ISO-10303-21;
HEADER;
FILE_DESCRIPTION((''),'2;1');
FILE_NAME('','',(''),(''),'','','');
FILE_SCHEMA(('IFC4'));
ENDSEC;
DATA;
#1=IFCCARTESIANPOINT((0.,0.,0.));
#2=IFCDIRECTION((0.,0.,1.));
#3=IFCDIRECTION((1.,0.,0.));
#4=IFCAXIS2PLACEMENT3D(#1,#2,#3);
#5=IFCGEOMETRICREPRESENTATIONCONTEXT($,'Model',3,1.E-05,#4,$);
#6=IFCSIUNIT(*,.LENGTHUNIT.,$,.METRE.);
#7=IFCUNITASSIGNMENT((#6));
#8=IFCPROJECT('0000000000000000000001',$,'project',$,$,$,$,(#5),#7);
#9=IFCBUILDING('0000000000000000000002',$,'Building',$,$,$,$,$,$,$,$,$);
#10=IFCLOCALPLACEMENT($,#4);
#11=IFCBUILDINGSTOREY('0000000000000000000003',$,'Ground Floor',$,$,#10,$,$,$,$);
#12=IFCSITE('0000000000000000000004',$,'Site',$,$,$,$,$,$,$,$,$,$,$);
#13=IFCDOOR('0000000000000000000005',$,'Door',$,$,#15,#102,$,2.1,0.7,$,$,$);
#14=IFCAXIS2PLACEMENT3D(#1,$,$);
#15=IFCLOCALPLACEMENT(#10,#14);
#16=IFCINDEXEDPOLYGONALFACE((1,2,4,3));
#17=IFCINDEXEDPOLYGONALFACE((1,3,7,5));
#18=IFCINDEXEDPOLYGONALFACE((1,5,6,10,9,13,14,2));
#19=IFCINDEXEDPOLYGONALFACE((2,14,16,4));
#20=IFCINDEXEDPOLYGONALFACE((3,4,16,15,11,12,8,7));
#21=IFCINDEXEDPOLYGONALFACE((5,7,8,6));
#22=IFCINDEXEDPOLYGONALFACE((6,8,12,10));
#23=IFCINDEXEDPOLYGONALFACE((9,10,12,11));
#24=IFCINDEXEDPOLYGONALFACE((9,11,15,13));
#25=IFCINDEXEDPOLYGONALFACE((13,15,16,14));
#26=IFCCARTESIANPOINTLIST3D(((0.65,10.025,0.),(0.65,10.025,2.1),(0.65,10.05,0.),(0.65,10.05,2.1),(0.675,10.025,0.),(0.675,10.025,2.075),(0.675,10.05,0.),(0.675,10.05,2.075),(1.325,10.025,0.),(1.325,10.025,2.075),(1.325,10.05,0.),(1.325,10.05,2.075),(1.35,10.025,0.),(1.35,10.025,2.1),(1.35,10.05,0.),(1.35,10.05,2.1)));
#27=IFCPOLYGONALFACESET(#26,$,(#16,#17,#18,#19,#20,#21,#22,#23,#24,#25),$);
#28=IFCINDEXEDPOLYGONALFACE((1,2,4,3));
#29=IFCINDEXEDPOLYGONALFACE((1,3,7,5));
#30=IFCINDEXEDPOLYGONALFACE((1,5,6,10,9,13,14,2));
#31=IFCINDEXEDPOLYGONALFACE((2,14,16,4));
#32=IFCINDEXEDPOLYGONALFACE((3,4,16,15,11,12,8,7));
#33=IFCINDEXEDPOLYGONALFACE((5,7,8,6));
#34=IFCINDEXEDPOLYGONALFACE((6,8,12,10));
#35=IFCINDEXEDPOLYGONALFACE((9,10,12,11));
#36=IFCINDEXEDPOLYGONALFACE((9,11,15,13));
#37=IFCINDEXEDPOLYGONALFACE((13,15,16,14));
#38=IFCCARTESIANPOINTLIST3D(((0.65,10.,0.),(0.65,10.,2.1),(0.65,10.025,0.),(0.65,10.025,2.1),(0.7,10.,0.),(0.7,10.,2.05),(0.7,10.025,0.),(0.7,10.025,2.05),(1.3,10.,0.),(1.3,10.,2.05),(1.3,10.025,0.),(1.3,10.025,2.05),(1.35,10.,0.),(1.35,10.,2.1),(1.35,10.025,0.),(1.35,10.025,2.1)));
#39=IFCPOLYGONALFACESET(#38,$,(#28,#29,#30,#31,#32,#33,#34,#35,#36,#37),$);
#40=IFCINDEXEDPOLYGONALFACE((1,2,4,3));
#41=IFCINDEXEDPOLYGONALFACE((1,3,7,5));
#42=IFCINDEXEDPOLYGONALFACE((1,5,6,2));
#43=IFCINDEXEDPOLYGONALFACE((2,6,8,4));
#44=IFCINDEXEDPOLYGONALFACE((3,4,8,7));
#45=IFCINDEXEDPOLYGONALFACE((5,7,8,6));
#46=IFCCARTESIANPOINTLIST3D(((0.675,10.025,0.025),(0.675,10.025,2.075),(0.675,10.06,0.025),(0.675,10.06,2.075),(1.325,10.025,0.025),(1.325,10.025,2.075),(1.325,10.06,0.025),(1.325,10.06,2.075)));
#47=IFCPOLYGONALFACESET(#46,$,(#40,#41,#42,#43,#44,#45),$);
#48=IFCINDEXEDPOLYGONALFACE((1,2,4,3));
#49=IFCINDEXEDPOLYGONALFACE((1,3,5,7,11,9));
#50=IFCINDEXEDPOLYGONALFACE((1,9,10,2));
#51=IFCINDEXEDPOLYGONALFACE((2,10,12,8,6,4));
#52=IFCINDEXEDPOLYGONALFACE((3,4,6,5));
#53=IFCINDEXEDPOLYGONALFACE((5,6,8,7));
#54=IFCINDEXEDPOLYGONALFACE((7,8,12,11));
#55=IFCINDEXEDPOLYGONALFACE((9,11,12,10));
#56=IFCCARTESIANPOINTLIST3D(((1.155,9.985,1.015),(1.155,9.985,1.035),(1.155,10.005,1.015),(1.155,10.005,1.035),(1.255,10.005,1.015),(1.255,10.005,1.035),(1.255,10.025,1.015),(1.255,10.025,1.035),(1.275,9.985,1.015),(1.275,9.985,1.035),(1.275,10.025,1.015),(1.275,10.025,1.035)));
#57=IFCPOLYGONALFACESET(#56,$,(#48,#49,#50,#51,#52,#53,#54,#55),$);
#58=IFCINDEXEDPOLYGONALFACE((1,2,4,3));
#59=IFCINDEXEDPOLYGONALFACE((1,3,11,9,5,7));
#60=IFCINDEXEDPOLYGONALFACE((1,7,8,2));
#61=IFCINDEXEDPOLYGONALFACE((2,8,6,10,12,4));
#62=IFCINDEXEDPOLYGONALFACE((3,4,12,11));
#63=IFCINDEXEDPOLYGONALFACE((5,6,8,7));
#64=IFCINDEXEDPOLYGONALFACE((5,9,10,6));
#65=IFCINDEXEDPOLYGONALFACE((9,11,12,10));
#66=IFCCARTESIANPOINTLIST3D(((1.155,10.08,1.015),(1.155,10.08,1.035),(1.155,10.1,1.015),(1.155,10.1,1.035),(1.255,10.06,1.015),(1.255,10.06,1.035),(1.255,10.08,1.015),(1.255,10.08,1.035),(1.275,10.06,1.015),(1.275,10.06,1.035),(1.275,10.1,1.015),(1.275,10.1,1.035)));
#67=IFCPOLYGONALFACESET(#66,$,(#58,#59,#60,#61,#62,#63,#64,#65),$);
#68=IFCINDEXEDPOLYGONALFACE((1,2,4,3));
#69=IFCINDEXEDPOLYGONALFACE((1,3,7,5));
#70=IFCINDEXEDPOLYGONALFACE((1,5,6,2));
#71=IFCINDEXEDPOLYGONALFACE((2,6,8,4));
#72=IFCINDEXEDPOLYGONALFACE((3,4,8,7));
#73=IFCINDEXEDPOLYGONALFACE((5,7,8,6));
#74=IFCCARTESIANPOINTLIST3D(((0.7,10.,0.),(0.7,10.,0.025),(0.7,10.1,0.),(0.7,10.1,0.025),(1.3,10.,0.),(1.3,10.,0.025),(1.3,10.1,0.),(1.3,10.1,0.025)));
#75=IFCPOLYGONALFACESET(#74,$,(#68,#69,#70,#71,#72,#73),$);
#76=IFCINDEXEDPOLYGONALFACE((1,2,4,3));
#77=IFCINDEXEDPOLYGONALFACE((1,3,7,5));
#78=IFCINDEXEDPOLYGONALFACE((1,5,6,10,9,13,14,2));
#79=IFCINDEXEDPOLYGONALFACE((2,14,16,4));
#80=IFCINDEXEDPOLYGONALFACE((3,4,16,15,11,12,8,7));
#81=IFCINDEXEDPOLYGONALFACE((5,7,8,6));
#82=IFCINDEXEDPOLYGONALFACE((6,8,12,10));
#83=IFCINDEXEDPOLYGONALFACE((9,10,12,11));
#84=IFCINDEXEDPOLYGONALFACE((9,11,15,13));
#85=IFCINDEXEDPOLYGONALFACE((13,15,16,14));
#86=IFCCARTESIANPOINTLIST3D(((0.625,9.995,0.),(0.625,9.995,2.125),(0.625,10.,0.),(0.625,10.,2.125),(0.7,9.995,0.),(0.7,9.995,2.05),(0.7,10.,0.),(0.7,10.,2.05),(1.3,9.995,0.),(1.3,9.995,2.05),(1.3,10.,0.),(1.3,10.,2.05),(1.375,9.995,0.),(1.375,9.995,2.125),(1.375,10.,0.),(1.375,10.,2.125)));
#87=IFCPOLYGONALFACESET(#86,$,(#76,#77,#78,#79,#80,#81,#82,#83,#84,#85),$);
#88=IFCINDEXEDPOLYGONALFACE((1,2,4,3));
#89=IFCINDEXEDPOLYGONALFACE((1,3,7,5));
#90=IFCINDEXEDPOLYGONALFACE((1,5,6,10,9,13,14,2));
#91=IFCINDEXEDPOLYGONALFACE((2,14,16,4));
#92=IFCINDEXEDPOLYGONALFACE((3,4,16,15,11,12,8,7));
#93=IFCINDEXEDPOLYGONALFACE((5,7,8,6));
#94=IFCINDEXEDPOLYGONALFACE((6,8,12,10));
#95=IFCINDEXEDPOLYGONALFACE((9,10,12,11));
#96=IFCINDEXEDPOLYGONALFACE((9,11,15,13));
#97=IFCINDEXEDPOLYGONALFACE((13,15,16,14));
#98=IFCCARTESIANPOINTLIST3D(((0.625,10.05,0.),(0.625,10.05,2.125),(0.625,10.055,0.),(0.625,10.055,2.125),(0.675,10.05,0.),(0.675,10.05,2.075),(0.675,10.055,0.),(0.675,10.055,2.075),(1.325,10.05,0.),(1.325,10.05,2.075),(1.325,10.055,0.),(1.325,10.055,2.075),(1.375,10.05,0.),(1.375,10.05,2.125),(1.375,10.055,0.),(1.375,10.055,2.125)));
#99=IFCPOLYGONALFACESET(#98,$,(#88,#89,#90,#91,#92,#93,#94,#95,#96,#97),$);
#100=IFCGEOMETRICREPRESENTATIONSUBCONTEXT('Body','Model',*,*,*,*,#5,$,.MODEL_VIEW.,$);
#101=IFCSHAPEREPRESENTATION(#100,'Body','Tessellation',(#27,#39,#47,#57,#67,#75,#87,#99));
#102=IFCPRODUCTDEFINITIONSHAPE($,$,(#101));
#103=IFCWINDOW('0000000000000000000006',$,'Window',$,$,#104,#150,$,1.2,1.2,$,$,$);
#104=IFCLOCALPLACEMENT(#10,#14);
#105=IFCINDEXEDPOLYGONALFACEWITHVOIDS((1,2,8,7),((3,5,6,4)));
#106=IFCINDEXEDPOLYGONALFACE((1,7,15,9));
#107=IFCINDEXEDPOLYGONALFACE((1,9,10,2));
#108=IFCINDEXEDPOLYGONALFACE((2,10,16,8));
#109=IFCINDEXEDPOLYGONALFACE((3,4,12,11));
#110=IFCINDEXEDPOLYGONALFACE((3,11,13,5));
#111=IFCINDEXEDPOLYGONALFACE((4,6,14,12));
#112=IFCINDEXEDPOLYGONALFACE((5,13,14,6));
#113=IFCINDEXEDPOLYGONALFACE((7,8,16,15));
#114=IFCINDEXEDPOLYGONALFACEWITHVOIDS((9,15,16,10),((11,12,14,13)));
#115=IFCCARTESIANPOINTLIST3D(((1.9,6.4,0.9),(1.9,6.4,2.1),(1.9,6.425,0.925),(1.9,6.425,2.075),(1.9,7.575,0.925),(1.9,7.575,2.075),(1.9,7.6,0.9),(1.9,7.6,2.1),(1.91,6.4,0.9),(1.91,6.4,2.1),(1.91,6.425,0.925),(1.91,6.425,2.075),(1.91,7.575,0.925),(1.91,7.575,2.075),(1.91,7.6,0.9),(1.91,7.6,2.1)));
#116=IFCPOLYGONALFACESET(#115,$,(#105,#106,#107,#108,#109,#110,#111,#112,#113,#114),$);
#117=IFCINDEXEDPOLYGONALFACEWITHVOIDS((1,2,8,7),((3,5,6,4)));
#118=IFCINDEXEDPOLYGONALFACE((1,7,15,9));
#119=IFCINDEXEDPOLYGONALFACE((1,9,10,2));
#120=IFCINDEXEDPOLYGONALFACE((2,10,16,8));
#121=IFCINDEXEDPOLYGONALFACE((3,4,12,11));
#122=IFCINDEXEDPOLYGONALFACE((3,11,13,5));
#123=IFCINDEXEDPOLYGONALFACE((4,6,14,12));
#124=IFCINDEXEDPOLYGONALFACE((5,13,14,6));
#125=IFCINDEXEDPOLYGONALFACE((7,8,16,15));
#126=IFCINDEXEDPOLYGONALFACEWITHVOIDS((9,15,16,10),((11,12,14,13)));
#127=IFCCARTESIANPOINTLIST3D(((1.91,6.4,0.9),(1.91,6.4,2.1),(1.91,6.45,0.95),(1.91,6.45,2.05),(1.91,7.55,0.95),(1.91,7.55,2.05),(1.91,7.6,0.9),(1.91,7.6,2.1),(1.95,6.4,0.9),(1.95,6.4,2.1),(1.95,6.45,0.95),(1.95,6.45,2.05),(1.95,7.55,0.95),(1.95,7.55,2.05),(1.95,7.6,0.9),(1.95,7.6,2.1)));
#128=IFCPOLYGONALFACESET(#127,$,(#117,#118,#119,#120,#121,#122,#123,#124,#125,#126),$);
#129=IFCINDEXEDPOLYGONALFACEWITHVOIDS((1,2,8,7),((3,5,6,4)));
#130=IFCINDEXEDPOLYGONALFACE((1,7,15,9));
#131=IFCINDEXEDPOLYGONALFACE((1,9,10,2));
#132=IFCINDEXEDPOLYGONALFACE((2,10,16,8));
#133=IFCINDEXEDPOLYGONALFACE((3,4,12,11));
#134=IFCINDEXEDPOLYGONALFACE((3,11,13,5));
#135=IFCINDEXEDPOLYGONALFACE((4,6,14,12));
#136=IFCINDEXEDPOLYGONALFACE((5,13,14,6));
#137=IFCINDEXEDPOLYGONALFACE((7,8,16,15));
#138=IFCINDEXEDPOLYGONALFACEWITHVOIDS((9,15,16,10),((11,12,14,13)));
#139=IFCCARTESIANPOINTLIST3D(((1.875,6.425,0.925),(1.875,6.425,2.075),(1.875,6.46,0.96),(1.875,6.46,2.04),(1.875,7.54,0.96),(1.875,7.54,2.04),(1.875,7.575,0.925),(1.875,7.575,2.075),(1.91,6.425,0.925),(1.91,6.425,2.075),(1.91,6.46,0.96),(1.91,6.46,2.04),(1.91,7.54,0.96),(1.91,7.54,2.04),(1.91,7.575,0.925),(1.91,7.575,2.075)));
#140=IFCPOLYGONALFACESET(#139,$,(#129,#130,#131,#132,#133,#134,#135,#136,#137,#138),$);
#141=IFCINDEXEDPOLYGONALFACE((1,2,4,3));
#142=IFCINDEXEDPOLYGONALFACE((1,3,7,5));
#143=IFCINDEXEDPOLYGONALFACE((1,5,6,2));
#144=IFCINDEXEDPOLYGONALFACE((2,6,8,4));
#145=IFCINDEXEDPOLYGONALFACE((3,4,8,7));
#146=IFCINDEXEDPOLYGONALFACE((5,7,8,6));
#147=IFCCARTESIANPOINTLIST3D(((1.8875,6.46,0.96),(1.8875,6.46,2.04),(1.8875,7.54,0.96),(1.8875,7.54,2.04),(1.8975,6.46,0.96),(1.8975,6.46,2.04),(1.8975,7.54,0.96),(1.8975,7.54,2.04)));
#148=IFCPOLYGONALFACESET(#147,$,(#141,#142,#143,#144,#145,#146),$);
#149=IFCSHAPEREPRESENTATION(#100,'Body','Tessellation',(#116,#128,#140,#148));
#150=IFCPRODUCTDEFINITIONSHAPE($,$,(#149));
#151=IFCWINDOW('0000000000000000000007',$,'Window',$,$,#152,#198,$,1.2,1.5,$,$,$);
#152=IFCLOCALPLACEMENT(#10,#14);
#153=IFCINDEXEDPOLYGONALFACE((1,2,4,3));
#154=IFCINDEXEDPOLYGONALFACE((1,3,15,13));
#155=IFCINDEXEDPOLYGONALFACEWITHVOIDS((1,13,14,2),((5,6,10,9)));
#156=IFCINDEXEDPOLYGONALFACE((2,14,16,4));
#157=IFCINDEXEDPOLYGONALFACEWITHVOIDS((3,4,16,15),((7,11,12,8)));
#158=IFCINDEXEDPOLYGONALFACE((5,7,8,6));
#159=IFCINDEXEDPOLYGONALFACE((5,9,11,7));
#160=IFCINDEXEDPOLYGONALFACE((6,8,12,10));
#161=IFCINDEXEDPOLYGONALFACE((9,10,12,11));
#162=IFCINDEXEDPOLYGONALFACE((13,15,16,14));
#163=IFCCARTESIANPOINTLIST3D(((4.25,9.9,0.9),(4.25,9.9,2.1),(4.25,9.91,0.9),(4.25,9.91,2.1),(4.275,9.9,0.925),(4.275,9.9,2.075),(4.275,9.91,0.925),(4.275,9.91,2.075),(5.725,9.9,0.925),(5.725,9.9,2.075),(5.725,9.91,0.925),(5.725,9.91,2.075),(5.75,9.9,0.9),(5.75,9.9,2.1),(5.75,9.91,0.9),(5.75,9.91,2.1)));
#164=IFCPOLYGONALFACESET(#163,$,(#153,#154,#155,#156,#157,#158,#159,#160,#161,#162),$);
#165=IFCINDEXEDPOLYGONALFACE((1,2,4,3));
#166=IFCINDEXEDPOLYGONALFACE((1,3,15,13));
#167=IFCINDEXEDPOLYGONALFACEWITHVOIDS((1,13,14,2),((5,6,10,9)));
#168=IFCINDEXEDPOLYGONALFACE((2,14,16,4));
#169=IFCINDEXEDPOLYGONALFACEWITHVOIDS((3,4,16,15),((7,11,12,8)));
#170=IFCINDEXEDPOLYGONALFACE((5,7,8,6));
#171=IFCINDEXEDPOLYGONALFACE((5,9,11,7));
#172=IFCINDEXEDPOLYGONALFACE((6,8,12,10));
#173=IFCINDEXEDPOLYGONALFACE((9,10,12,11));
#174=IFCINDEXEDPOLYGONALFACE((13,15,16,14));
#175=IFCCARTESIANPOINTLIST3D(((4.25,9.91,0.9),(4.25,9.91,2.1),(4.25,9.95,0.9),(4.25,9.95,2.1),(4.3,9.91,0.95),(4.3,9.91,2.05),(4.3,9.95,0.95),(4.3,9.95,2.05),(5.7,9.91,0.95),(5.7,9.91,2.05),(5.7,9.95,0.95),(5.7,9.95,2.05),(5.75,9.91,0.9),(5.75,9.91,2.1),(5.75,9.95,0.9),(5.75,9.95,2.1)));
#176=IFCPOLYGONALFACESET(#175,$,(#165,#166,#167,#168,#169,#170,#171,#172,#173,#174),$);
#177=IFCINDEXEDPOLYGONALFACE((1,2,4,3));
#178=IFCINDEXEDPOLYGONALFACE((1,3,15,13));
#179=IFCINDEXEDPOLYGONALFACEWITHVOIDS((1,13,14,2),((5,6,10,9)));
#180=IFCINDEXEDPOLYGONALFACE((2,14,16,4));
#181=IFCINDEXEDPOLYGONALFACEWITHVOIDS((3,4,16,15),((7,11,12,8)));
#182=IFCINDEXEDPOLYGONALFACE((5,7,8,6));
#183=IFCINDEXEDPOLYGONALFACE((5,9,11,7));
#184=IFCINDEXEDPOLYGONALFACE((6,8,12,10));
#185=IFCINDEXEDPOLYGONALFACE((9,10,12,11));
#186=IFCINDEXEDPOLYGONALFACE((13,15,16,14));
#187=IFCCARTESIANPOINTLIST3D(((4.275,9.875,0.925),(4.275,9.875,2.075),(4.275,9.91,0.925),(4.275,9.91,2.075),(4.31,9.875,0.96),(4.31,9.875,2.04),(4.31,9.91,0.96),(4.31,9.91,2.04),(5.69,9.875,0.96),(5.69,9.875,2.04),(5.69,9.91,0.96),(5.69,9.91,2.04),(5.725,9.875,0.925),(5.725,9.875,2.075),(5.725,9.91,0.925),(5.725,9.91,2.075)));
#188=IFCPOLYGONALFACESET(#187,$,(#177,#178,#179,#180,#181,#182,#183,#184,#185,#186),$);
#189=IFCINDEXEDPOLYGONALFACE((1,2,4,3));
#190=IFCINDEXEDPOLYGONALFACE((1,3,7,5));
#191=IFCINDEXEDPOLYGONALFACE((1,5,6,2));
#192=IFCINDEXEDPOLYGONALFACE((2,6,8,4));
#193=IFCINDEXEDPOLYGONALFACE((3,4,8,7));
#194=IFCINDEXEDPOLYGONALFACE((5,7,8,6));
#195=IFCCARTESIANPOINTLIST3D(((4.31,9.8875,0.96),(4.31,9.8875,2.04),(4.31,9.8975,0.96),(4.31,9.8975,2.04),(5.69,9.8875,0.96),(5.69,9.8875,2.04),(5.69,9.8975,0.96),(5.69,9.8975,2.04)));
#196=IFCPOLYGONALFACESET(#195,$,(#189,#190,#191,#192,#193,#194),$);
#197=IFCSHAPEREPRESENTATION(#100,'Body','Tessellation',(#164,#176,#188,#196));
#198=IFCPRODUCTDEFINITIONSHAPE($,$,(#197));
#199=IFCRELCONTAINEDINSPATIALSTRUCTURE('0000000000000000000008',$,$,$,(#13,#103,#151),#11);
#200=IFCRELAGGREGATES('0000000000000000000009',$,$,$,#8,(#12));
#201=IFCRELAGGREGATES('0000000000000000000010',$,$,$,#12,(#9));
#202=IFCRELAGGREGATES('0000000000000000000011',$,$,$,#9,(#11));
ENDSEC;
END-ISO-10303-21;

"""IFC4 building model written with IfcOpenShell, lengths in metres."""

from ifc_helpers import new_model, si_unit, frame, origin_with_axes, place, context, subcontext, project, spatial, line, indexed_curve, outline, extrude, element, save


model = new_model("IFC4")

# Units and contexts
model_context = context("Model", 3, precision=1e-05, world=origin_with_axes())
body_context = subcontext(model_context, "Body", "Model", "MODEL_VIEW")
ifc_project = project(units=[si_unit("LENGTHUNIT", "METRE")], contexts=[model_context])

# Site, building, storey
site = spatial("IfcSite", under=ifc_project, Name="Site")
building = spatial("IfcBuilding", under=site, Name="Building")
storey_placement = place(None, origin_with_axes())
storey = spatial("IfcBuildingStorey", under=building, at=storey_placement, Name="Ground Floor")

# Door
door_1_placement = place(storey_placement, frame((0.65, 10.0, 0.0), z_axis=(0.0, 0.0, 1.0), x_axis=(1.0, 0.0, 0.0)))
element("IfcDoor", 1, at=door_1_placement, inside=storey, Name="Door", OverallHeight=2.1, OverallWidth=0.7, context=body_context, shape_type="SweptSolid", body=[
    extrude(outline(indexed_curve([(0.0, 0.0), (0.0, 2.1), (0.7, 2.1), (0.7, 0.0), (0.675, 0.0), (0.675, 2.075), (0.025, 2.075), (0.025, 0.0)], segments=[line(1, 2, 3, 4, 5, 6, 7, 8, 1)])), frame((0.0, 0.025, 0.0), z_axis=(0.0, -1.0, 0.0), x_axis=(1.0, 0.0, 0.0)), (0.0, 0.0, -1.0), 0.025),
    extrude(outline(indexed_curve([(0.0, 0.0), (0.0, 2.1), (0.7, 2.1), (0.7, 0.0), (0.65, 0.0), (0.65, 2.05), (0.05, 2.05), (0.05, 0.0)], segments=[line(1, 2, 3, 4, 5, 6, 7, 8, 1)])), frame((0.0, 0.0, 0.0), z_axis=(0.0, -1.0, 0.0), x_axis=(1.0, 0.0, 0.0)), (0.0, 0.0, -1.0), 0.025),
    extrude(outline(indexed_curve([(0.0, 0.0), (0.65, 0.0), (0.65, 0.035), (0.0, 0.035)], segments=[line(1, 2, 3, 4, 1)])), frame((0.025, 0.025, 0.025), z_axis=(0.0, 0.0, 1.0), x_axis=(1.0, 0.0, 0.0)), (0.0, 0.0, 1.0), 2.05),
    extrude(outline(indexed_curve([(0.0, 0.0), (0.0, -0.04), (-0.12, -0.04), (-0.12, -0.02), (-0.02, -0.02), (-0.02, 0.0)], segments=[line(1, 2, 3, 4, 5, 6, 1)])), frame((0.625, 0.025, 1.015), z_axis=(0.0, 0.0, 1.0), x_axis=(1.0, 0.0, 0.0)), (0.0, 0.0, 1.0), 0.02),
    extrude(outline(indexed_curve([(0.0, 0.0), (0.0, 0.04), (-0.12, 0.04), (-0.12, 0.02), (-0.02, 0.02), (-0.02, 0.0)], segments=[line(1, 2, 3, 4, 5, 6, 1)])), frame((0.625, 0.06, 1.015), z_axis=(0.0, 0.0, 1.0), x_axis=(1.0, 0.0, 0.0)), (0.0, 0.0, 1.0), 0.02),
    extrude(outline(indexed_curve([(0.0, 0.0), (0.6, 0.0), (0.6, 0.1), (0.0, 0.1)], segments=[line(1, 2, 3, 4, 1)])), frame((0.05, 0.0, 0.0), z_axis=(0.0, 0.0, 1.0), x_axis=(1.0, 0.0, 0.0)), (0.0, 0.0, 1.0), 0.025),
    extrude(outline(indexed_curve([(0.0, 0.0), (0.0, 2.125), (0.75, 2.125), (0.75, 0.0), (0.675, 0.0), (0.675, 2.05), (0.075, 2.05), (0.075, 0.0)], segments=[line(1, 2, 3, 4, 5, 6, 7, 8, 1)])), frame((-0.025, -0.005, 0.0), z_axis=(0.0, -1.0, 0.0), x_axis=(1.0, 0.0, 0.0)), (0.0, 0.0, -1.0), 0.005),
    extrude(outline(indexed_curve([(0.0, 0.0), (0.0, 2.125), (0.75, 2.125), (0.75, 0.0), (0.7, 0.0), (0.7, 2.075), (0.05, 2.075), (0.05, 0.0)], segments=[line(1, 2, 3, 4, 5, 6, 7, 8, 1)])), frame((-0.025, 0.05, 0.0), z_axis=(0.0, -1.0, 0.0), x_axis=(1.0, 0.0, 0.0)), (0.0, 0.0, -1.0), 0.005),
])

# Windows
window_1_placement = place(storey_placement, frame((2.0, 6.4, 0.9), z_axis=(0.0, 0.0, 1.0), x_axis=(0.0, 1.0, 0.0)))
element("IfcWindow", 2, at=window_1_placement, inside=storey, Name="Window", OverallHeight=1.2, OverallWidth=1.2, context=body_context, shape_type="SweptSolid", body=[
    extrude(outline(indexed_curve([(0.0, 0.0), (1.2, 0.0), (1.2, 1.2), (0.0, 1.2)], segments=[line(1, 2, 3, 4, 1)]), holes=[indexed_curve([(0.025, 0.025), (1.175, 0.025), (1.175, 1.175), (0.025, 1.175)], segments=[line(1, 2, 3, 4, 1)])]), frame((0.0, 0.09, 0.0), z_axis=(0.0, -1.0, 0.0), x_axis=(1.0, 0.0, 0.0)), (0.0, 0.0, -1.0), 0.01),
    extrude(outline(indexed_curve([(0.0, 0.0), (1.2, 0.0), (1.2, 1.2), (0.0, 1.2)], segments=[line(1, 2, 3, 4, 1)]), holes=[indexed_curve([(0.05, 0.05), (1.15, 0.05), (1.15, 1.15), (0.05, 1.15)], segments=[line(1, 2, 3, 4, 1)])]), frame((0.0, 0.05, 0.0), z_axis=(0.0, -1.0, 0.0), x_axis=(1.0, 0.0, 0.0)), (0.0, 0.0, -1.0), 0.04),
    extrude(outline(indexed_curve([(0.0, 0.0), (1.15, 0.0), (1.15, 1.15), (0.0, 1.15)], segments=[line(1, 2, 3, 4, 1)]), holes=[indexed_curve([(0.035, 0.035), (1.115, 0.035), (1.115, 1.115), (0.035, 1.115)], segments=[line(1, 2, 3, 4, 1)])]), frame((0.025, 0.09, 0.025), z_axis=(0.0, -1.0, 0.0), x_axis=(1.0, 0.0, 0.0)), (0.0, 0.0, -1.0), 0.035),
    extrude(outline(indexed_curve([(0.035, 0.035), (1.115, 0.035), (1.115, 1.115), (0.035, 1.115)], segments=[line(1, 2, 3, 4, 1)])), frame((0.025, 0.1025, 0.025), z_axis=(0.0, -1.0, 0.0), x_axis=(1.0, 0.0, 0.0)), (0.0, 0.0, -1.0), 0.01),
])
window_2_placement = place(storey_placement, frame((5.75, 10.0, 0.9), z_axis=(0.0, 0.0, 1.0), x_axis=(-1.0, 0.0, 0.0)))
element("IfcWindow", 3, at=window_2_placement, inside=storey, Name="Window", OverallHeight=1.2, OverallWidth=1.5, context=body_context, shape_type="SweptSolid", body=[
    extrude(outline(indexed_curve([(0.0, 0.0), (1.5, 0.0), (1.5, 1.2), (0.0, 1.2)], segments=[line(1, 2, 3, 4, 1)]), holes=[indexed_curve([(0.025, 0.025), (1.475, 0.025), (1.475, 1.175), (0.025, 1.175)], segments=[line(1, 2, 3, 4, 1)])]), frame((0.0, 0.09, 0.0), z_axis=(0.0, -1.0, 0.0), x_axis=(1.0, 0.0, 0.0)), (0.0, 0.0, -1.0), 0.01),
    extrude(outline(indexed_curve([(0.0, 0.0), (1.5, 0.0), (1.5, 1.2), (0.0, 1.2)], segments=[line(1, 2, 3, 4, 1)]), holes=[indexed_curve([(0.05, 0.05), (1.45, 0.05), (1.45, 1.15), (0.05, 1.15)], segments=[line(1, 2, 3, 4, 1)])]), frame((0.0, 0.05, 0.0), z_axis=(0.0, -1.0, 0.0), x_axis=(1.0, 0.0, 0.0)), (0.0, 0.0, -1.0), 0.04),
    extrude(outline(indexed_curve([(0.0, 0.0), (1.45, 0.0), (1.45, 1.15), (0.0, 1.15)], segments=[line(1, 2, 3, 4, 1)]), holes=[indexed_curve([(0.035, 0.035), (1.415, 0.035), (1.415, 1.115), (0.035, 1.115)], segments=[line(1, 2, 3, 4, 1)])]), frame((0.025, 0.09, 0.025), z_axis=(0.0, -1.0, 0.0), x_axis=(1.0, 0.0, 0.0)), (0.0, 0.0, -1.0), 0.035),
    extrude(outline(indexed_curve([(0.035, 0.035), (1.415, 0.035), (1.415, 1.115), (0.035, 1.115)], segments=[line(1, 2, 3, 4, 1)])), frame((0.025, 0.1025, 0.025), z_axis=(0.0, -1.0, 0.0), x_axis=(1.0, 0.0, 0.0)), (0.0, 0.0, -1.0), 0.01),
])

save(model, "model.ifc")
